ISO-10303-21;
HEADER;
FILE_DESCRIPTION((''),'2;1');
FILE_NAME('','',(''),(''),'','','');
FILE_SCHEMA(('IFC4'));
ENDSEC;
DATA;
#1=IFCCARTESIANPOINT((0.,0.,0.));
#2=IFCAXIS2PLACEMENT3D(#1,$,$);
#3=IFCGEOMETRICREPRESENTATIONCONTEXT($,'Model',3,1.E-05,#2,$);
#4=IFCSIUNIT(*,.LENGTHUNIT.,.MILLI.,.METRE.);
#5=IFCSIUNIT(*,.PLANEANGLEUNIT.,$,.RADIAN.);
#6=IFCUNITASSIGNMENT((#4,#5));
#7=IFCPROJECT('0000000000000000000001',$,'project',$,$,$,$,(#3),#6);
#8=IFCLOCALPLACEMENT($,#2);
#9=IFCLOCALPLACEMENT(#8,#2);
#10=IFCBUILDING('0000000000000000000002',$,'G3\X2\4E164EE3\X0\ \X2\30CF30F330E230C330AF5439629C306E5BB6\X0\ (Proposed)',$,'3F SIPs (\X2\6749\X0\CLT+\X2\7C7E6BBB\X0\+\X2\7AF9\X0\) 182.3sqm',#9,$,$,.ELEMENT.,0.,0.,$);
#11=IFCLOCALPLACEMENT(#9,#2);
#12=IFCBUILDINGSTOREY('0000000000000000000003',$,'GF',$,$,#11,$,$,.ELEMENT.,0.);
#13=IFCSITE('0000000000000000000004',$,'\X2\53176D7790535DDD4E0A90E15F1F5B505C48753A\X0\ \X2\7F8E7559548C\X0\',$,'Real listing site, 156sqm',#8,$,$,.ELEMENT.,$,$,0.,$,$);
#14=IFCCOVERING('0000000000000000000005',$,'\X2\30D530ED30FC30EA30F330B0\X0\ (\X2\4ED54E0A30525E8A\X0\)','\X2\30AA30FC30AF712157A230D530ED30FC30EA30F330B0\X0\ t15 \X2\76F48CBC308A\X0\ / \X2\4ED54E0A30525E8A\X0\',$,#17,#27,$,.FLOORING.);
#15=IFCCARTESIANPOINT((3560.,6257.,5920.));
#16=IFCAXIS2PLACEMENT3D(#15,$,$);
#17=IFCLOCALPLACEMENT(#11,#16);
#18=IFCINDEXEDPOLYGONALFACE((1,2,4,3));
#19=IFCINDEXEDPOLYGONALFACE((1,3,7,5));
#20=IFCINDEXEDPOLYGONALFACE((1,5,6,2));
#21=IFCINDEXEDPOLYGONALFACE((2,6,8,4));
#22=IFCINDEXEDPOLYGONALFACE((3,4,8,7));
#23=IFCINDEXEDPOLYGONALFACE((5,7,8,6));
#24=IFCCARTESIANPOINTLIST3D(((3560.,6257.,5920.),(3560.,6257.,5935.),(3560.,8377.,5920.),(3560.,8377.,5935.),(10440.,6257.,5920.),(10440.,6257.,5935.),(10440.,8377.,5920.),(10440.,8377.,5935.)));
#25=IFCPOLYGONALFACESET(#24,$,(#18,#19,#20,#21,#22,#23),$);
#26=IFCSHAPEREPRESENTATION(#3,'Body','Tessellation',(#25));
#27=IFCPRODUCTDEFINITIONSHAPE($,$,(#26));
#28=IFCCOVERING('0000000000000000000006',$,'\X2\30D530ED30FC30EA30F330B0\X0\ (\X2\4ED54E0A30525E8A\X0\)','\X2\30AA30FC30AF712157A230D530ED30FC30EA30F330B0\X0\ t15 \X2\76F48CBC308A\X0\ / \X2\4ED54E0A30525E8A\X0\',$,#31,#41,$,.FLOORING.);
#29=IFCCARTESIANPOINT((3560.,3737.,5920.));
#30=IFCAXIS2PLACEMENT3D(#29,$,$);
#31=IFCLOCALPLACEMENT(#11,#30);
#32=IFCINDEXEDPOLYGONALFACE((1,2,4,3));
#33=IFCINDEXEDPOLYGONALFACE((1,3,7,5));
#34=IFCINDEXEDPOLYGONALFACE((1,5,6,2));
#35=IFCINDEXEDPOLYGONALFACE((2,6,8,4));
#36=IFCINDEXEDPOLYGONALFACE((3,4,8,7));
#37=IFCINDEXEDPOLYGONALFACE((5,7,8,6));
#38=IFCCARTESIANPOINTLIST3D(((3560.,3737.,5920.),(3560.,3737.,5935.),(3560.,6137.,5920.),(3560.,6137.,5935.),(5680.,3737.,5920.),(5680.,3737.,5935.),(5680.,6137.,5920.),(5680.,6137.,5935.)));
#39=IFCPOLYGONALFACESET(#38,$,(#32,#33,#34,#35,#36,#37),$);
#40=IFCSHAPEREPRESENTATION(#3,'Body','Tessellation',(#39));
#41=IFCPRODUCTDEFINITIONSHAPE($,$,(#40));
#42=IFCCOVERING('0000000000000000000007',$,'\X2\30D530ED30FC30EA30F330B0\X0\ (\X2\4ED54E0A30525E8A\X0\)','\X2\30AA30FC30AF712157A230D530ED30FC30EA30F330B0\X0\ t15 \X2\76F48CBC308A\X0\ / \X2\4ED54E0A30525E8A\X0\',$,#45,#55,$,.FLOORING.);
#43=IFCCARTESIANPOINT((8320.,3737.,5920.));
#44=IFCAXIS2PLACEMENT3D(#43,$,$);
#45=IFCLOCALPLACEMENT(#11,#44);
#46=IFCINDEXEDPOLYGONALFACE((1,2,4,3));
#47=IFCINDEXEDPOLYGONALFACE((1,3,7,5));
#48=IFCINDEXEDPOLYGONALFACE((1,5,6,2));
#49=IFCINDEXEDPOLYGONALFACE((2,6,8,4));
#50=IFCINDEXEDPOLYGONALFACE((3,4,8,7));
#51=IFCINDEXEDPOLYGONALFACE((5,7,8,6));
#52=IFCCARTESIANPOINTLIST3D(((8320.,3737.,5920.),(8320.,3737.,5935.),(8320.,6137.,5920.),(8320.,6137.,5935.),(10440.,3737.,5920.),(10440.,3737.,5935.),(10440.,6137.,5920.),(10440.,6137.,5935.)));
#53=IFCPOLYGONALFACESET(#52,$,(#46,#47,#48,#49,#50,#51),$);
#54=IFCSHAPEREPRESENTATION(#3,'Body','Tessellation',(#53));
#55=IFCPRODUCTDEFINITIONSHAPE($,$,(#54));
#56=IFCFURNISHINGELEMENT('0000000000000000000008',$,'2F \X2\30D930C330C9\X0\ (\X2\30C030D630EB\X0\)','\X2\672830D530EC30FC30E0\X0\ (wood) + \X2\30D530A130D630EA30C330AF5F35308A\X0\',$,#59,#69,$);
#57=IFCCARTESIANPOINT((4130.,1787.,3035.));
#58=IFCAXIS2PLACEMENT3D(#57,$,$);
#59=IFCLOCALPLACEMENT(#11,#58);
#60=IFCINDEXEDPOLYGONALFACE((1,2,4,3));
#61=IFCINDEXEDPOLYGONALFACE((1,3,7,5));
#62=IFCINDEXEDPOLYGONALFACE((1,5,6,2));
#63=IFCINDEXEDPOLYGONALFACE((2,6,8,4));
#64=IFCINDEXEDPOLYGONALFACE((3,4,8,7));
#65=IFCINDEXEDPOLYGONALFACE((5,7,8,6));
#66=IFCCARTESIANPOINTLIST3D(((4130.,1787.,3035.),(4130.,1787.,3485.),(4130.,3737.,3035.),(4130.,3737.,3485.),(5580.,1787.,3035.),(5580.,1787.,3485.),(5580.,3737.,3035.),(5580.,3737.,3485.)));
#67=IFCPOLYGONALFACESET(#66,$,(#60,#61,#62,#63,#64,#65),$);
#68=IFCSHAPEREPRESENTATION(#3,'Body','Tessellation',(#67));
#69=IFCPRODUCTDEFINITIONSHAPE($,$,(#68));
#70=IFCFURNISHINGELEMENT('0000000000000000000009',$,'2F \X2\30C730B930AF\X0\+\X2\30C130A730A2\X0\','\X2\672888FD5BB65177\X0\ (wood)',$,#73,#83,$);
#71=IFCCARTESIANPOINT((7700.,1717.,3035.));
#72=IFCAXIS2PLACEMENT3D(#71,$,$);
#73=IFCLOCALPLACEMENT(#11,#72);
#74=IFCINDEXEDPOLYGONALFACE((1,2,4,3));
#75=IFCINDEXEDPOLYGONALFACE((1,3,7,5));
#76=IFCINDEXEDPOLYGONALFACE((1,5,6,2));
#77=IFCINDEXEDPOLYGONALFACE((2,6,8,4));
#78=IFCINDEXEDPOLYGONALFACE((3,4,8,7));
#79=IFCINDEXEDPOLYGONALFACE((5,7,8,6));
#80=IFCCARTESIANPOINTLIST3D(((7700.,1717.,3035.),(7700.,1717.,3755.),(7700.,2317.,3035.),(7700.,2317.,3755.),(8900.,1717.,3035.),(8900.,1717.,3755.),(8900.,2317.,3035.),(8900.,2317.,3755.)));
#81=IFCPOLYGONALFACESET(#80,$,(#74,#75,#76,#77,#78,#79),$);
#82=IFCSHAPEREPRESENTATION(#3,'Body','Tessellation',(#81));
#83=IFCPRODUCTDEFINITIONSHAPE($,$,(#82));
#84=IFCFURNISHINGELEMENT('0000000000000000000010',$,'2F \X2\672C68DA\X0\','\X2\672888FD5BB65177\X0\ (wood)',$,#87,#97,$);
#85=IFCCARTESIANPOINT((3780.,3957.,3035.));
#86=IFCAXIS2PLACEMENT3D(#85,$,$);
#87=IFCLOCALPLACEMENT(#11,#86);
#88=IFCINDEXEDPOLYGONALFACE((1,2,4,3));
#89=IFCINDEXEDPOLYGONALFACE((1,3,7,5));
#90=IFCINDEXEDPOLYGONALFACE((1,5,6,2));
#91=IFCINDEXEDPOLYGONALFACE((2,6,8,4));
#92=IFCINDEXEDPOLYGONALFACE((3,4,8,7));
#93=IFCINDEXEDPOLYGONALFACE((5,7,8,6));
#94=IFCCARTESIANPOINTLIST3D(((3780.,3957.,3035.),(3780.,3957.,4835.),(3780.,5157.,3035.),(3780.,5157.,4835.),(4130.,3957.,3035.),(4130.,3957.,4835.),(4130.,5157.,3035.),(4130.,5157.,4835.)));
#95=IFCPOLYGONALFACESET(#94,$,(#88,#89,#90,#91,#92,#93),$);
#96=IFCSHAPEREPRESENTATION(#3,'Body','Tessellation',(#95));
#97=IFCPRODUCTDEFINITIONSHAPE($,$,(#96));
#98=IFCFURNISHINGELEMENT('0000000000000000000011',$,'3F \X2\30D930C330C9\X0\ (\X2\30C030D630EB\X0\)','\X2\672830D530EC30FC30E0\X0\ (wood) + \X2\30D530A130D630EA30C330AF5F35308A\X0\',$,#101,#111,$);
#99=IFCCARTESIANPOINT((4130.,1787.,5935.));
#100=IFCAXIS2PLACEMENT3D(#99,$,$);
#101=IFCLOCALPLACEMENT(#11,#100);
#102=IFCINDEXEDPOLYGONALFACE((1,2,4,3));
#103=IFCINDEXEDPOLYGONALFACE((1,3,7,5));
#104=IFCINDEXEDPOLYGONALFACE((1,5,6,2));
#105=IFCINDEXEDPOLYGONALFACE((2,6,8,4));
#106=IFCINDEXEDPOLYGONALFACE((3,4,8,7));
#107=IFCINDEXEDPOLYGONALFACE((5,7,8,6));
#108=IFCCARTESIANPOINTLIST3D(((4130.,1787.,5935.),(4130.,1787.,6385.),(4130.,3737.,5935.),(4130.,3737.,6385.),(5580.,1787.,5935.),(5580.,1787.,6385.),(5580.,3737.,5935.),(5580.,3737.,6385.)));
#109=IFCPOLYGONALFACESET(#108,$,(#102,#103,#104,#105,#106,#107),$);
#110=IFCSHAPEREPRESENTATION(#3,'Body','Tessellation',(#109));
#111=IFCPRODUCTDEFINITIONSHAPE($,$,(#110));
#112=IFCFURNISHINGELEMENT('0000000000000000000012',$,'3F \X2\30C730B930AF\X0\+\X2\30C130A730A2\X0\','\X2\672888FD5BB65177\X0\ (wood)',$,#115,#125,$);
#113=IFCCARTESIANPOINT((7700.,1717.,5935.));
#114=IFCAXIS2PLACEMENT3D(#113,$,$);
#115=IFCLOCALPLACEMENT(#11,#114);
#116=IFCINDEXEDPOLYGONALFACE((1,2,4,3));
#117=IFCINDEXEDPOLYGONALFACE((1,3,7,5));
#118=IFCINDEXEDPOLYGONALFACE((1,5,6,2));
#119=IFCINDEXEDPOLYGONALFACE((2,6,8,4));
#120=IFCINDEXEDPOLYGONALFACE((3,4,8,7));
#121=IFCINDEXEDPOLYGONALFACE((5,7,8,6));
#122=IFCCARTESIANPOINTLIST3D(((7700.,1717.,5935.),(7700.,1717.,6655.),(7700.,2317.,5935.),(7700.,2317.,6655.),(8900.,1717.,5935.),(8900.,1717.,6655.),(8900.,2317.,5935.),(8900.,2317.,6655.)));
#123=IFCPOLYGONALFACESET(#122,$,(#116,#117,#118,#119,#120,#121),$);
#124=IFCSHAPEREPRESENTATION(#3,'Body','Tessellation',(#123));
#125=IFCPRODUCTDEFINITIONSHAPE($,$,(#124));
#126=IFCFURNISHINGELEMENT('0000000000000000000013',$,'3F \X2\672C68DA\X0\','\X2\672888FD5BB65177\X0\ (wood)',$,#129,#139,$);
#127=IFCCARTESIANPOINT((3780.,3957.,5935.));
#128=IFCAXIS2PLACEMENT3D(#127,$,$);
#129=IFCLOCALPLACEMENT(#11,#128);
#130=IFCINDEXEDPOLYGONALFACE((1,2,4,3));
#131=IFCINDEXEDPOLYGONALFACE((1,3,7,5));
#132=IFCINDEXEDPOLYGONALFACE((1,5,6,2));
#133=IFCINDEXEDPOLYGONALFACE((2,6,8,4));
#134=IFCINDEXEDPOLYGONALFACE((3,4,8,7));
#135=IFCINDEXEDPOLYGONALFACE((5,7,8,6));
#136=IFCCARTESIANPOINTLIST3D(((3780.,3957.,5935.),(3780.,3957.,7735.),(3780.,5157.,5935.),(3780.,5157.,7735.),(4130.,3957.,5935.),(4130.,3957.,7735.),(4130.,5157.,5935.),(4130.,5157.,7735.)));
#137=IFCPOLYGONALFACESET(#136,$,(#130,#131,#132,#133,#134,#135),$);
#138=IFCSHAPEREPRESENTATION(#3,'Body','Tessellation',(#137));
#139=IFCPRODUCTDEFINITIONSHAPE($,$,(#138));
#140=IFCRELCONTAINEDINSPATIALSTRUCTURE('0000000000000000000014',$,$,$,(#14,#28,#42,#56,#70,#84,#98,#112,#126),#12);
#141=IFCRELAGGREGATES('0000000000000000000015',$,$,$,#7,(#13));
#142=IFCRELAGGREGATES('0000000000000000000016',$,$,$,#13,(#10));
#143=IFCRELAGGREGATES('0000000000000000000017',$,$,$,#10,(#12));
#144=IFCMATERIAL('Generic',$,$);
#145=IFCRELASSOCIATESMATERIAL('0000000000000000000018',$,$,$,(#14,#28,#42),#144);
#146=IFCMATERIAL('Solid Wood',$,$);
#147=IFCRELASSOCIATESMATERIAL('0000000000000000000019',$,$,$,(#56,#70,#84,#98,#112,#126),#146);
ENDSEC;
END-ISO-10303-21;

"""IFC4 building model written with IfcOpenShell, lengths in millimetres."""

from ifc_helpers import new_model, si_unit, frame, frame_2d, origin, place, context, project, spatial, rectangle, extrude, material, element, save


model = new_model("IFC4")

# Units and contexts
model_context = context("Model", 3, precision=1e-05, world=origin())
ifc_project = project(units=[si_unit("LENGTHUNIT", "METRE", prefix="MILLI"), si_unit("PLANEANGLEUNIT", "RADIAN")], contexts=[model_context])

# Site, building, storey
site_placement = place(None, origin())
site = spatial("IfcSite", under=ifc_project, at=site_placement, Name="北海道川上郡弟子屈町 美留和", ObjectType="Real listing site, 156sqm", CompositionType="ELEMENT", RefElevation=0.0)
building_placement = place(site_placement, origin())
building = spatial("IfcBuilding", under=site, at=building_placement, Name="G3世代 ハンモック吹抜の家 (Proposed)", ObjectType="3F SIPs (杉CLT+籾殻+竹) 182.3sqm", CompositionType="ELEMENT", ElevationOfRefHeight=0.0, ElevationOfTerrain=0.0)
storey_placement = place(building_placement, origin())
storey = spatial("IfcBuildingStorey", under=building, at=storey_placement, Name="GF", CompositionType="ELEMENT", Elevation=0.0)

# Shared definitions
ifc_material_1 = material(Name="Solid Wood")

# Shared definitions
ifc_material_2 = material(Name="Generic")

# Coverings
covering_1_placement = place(storey_placement, frame((3560.0, 6257.0, 5920.0)))
element("IfcCovering", 1, at=covering_1_placement, inside=storey, material=ifc_material_2, Name="フローリング (仕上げ床)", Description="オーク無垢フローリング t15 直貼り / 仕上げ床", PredefinedType="FLOORING", context=model_context, shape_type="SweptSolid", body=[
    extrude(rectangle(XDim=6880.0, YDim=2120.0, at=frame_2d((3440.0, 1060.0))), frame((3560.0, 6257.0, 5920.0)), (0.0, 0.0, 1.0), 15.0),
])
covering_2_placement = place(storey_placement, frame((3560.0, 3737.0, 5920.0)))
element("IfcCovering", 2, at=covering_2_placement, inside=storey, material=ifc_material_2, Name="フローリング (仕上げ床)", Description="オーク無垢フローリング t15 直貼り / 仕上げ床", PredefinedType="FLOORING", context=model_context, shape_type="SweptSolid", body=[
    extrude(rectangle(XDim=2120.0, YDim=2400.0, at=frame_2d((1060.0, 1200.0))), frame((3560.0, 3737.0, 5920.0)), (0.0, 0.0, 1.0), 15.0),
])
covering_3_placement = place(storey_placement, frame((8320.0, 3737.0, 5920.0)))
element("IfcCovering", 3, at=covering_3_placement, inside=storey, material=ifc_material_2, Name="フローリング (仕上げ床)", Description="オーク無垢フローリング t15 直貼り / 仕上げ床", PredefinedType="FLOORING", context=model_context, shape_type="SweptSolid", body=[
    extrude(rectangle(XDim=2120.0, YDim=2400.0, at=frame_2d((1060.0, 1200.0))), frame((8320.0, 3737.0, 5920.0)), (0.0, 0.0, 1.0), 15.0),
])

# Furnishing elements
furnishing_1_placement = place(storey_placement, frame((4130.0, 1787.0, 3035.0)))
element("IfcFurnishingElement", 4, at=furnishing_1_placement, inside=storey, material=ifc_material_1, Name="2F ベッド (ダブル)", Description="木フレーム (wood) + ファブリック張り", context=model_context, shape_type="SweptSolid", body=[
    extrude(rectangle(XDim=1450.0, YDim=1950.0, at=frame_2d((725.0, 975.0))), frame((4130.0, 1787.0, 3035.0)), (0.0, 0.0, 1.0), 450.0),
])
furnishing_2_placement = place(storey_placement, frame((7700.0, 1717.0, 3035.0)))
element("IfcFurnishingElement", 5, at=furnishing_2_placement, inside=storey, material=ifc_material_1, Name="2F デスク+チェア", Description="木製家具 (wood)", context=model_context, shape_type="SweptSolid", body=[
    extrude(rectangle(XDim=1200.0, YDim=600.0, at=frame_2d((600.0, 300.0))), frame((7700.0, 1717.0, 3035.0)), (0.0, 0.0, 1.0), 720.0),
])
furnishing_3_placement = place(storey_placement, frame((3780.0, 3957.0, 3035.0)))
element("IfcFurnishingElement", 6, at=furnishing_3_placement, inside=storey, material=ifc_material_1, Name="2F 本棚", Description="木製家具 (wood)", context=model_context, shape_type="SweptSolid", body=[
    extrude(rectangle(XDim=350.0, YDim=1200.0, at=frame_2d((175.0, 600.0))), frame((3780.0, 3957.0, 3035.0)), (0.0, 0.0, 1.0), 1800.0),
])
furnishing_4_placement = place(storey_placement, frame((4130.0, 1787.0, 5935.0)))
element("IfcFurnishingElement", 7, at=furnishing_4_placement, inside=storey, material=ifc_material_1, Name="3F ベッド (ダブル)", Description="木フレーム (wood) + ファブリック張り", context=model_context, shape_type="SweptSolid", body=[
    extrude(rectangle(XDim=1450.0, YDim=1950.0, at=frame_2d((725.0, 975.0))), frame((4130.0, 1787.0, 5935.0)), (0.0, 0.0, 1.0), 450.0),
])
furnishing_5_placement = place(storey_placement, frame((7700.0, 1717.0, 5935.0)))
element("IfcFurnishingElement", 8, at=furnishing_5_placement, inside=storey, material=ifc_material_1, Name="3F デスク+チェア", Description="木製家具 (wood)", context=model_context, shape_type="SweptSolid", body=[
    extrude(rectangle(XDim=1200.0, YDim=600.0, at=frame_2d((600.0, 300.0))), frame((7700.0, 1717.0, 5935.0)), (0.0, 0.0, 1.0), 720.0),
])
furnishing_6_placement = place(storey_placement, frame((3780.0, 3957.0, 5935.0)))
element("IfcFurnishingElement", 9, at=furnishing_6_placement, inside=storey, material=ifc_material_1, Name="3F 本棚", Description="木製家具 (wood)", context=model_context, shape_type="SweptSolid", body=[
    extrude(rectangle(XDim=350.0, YDim=1200.0, at=frame_2d((175.0, 600.0))), frame((3780.0, 3957.0, 5935.0)), (0.0, 0.0, 1.0), 1800.0),
])

save(model, "model.ifc")
